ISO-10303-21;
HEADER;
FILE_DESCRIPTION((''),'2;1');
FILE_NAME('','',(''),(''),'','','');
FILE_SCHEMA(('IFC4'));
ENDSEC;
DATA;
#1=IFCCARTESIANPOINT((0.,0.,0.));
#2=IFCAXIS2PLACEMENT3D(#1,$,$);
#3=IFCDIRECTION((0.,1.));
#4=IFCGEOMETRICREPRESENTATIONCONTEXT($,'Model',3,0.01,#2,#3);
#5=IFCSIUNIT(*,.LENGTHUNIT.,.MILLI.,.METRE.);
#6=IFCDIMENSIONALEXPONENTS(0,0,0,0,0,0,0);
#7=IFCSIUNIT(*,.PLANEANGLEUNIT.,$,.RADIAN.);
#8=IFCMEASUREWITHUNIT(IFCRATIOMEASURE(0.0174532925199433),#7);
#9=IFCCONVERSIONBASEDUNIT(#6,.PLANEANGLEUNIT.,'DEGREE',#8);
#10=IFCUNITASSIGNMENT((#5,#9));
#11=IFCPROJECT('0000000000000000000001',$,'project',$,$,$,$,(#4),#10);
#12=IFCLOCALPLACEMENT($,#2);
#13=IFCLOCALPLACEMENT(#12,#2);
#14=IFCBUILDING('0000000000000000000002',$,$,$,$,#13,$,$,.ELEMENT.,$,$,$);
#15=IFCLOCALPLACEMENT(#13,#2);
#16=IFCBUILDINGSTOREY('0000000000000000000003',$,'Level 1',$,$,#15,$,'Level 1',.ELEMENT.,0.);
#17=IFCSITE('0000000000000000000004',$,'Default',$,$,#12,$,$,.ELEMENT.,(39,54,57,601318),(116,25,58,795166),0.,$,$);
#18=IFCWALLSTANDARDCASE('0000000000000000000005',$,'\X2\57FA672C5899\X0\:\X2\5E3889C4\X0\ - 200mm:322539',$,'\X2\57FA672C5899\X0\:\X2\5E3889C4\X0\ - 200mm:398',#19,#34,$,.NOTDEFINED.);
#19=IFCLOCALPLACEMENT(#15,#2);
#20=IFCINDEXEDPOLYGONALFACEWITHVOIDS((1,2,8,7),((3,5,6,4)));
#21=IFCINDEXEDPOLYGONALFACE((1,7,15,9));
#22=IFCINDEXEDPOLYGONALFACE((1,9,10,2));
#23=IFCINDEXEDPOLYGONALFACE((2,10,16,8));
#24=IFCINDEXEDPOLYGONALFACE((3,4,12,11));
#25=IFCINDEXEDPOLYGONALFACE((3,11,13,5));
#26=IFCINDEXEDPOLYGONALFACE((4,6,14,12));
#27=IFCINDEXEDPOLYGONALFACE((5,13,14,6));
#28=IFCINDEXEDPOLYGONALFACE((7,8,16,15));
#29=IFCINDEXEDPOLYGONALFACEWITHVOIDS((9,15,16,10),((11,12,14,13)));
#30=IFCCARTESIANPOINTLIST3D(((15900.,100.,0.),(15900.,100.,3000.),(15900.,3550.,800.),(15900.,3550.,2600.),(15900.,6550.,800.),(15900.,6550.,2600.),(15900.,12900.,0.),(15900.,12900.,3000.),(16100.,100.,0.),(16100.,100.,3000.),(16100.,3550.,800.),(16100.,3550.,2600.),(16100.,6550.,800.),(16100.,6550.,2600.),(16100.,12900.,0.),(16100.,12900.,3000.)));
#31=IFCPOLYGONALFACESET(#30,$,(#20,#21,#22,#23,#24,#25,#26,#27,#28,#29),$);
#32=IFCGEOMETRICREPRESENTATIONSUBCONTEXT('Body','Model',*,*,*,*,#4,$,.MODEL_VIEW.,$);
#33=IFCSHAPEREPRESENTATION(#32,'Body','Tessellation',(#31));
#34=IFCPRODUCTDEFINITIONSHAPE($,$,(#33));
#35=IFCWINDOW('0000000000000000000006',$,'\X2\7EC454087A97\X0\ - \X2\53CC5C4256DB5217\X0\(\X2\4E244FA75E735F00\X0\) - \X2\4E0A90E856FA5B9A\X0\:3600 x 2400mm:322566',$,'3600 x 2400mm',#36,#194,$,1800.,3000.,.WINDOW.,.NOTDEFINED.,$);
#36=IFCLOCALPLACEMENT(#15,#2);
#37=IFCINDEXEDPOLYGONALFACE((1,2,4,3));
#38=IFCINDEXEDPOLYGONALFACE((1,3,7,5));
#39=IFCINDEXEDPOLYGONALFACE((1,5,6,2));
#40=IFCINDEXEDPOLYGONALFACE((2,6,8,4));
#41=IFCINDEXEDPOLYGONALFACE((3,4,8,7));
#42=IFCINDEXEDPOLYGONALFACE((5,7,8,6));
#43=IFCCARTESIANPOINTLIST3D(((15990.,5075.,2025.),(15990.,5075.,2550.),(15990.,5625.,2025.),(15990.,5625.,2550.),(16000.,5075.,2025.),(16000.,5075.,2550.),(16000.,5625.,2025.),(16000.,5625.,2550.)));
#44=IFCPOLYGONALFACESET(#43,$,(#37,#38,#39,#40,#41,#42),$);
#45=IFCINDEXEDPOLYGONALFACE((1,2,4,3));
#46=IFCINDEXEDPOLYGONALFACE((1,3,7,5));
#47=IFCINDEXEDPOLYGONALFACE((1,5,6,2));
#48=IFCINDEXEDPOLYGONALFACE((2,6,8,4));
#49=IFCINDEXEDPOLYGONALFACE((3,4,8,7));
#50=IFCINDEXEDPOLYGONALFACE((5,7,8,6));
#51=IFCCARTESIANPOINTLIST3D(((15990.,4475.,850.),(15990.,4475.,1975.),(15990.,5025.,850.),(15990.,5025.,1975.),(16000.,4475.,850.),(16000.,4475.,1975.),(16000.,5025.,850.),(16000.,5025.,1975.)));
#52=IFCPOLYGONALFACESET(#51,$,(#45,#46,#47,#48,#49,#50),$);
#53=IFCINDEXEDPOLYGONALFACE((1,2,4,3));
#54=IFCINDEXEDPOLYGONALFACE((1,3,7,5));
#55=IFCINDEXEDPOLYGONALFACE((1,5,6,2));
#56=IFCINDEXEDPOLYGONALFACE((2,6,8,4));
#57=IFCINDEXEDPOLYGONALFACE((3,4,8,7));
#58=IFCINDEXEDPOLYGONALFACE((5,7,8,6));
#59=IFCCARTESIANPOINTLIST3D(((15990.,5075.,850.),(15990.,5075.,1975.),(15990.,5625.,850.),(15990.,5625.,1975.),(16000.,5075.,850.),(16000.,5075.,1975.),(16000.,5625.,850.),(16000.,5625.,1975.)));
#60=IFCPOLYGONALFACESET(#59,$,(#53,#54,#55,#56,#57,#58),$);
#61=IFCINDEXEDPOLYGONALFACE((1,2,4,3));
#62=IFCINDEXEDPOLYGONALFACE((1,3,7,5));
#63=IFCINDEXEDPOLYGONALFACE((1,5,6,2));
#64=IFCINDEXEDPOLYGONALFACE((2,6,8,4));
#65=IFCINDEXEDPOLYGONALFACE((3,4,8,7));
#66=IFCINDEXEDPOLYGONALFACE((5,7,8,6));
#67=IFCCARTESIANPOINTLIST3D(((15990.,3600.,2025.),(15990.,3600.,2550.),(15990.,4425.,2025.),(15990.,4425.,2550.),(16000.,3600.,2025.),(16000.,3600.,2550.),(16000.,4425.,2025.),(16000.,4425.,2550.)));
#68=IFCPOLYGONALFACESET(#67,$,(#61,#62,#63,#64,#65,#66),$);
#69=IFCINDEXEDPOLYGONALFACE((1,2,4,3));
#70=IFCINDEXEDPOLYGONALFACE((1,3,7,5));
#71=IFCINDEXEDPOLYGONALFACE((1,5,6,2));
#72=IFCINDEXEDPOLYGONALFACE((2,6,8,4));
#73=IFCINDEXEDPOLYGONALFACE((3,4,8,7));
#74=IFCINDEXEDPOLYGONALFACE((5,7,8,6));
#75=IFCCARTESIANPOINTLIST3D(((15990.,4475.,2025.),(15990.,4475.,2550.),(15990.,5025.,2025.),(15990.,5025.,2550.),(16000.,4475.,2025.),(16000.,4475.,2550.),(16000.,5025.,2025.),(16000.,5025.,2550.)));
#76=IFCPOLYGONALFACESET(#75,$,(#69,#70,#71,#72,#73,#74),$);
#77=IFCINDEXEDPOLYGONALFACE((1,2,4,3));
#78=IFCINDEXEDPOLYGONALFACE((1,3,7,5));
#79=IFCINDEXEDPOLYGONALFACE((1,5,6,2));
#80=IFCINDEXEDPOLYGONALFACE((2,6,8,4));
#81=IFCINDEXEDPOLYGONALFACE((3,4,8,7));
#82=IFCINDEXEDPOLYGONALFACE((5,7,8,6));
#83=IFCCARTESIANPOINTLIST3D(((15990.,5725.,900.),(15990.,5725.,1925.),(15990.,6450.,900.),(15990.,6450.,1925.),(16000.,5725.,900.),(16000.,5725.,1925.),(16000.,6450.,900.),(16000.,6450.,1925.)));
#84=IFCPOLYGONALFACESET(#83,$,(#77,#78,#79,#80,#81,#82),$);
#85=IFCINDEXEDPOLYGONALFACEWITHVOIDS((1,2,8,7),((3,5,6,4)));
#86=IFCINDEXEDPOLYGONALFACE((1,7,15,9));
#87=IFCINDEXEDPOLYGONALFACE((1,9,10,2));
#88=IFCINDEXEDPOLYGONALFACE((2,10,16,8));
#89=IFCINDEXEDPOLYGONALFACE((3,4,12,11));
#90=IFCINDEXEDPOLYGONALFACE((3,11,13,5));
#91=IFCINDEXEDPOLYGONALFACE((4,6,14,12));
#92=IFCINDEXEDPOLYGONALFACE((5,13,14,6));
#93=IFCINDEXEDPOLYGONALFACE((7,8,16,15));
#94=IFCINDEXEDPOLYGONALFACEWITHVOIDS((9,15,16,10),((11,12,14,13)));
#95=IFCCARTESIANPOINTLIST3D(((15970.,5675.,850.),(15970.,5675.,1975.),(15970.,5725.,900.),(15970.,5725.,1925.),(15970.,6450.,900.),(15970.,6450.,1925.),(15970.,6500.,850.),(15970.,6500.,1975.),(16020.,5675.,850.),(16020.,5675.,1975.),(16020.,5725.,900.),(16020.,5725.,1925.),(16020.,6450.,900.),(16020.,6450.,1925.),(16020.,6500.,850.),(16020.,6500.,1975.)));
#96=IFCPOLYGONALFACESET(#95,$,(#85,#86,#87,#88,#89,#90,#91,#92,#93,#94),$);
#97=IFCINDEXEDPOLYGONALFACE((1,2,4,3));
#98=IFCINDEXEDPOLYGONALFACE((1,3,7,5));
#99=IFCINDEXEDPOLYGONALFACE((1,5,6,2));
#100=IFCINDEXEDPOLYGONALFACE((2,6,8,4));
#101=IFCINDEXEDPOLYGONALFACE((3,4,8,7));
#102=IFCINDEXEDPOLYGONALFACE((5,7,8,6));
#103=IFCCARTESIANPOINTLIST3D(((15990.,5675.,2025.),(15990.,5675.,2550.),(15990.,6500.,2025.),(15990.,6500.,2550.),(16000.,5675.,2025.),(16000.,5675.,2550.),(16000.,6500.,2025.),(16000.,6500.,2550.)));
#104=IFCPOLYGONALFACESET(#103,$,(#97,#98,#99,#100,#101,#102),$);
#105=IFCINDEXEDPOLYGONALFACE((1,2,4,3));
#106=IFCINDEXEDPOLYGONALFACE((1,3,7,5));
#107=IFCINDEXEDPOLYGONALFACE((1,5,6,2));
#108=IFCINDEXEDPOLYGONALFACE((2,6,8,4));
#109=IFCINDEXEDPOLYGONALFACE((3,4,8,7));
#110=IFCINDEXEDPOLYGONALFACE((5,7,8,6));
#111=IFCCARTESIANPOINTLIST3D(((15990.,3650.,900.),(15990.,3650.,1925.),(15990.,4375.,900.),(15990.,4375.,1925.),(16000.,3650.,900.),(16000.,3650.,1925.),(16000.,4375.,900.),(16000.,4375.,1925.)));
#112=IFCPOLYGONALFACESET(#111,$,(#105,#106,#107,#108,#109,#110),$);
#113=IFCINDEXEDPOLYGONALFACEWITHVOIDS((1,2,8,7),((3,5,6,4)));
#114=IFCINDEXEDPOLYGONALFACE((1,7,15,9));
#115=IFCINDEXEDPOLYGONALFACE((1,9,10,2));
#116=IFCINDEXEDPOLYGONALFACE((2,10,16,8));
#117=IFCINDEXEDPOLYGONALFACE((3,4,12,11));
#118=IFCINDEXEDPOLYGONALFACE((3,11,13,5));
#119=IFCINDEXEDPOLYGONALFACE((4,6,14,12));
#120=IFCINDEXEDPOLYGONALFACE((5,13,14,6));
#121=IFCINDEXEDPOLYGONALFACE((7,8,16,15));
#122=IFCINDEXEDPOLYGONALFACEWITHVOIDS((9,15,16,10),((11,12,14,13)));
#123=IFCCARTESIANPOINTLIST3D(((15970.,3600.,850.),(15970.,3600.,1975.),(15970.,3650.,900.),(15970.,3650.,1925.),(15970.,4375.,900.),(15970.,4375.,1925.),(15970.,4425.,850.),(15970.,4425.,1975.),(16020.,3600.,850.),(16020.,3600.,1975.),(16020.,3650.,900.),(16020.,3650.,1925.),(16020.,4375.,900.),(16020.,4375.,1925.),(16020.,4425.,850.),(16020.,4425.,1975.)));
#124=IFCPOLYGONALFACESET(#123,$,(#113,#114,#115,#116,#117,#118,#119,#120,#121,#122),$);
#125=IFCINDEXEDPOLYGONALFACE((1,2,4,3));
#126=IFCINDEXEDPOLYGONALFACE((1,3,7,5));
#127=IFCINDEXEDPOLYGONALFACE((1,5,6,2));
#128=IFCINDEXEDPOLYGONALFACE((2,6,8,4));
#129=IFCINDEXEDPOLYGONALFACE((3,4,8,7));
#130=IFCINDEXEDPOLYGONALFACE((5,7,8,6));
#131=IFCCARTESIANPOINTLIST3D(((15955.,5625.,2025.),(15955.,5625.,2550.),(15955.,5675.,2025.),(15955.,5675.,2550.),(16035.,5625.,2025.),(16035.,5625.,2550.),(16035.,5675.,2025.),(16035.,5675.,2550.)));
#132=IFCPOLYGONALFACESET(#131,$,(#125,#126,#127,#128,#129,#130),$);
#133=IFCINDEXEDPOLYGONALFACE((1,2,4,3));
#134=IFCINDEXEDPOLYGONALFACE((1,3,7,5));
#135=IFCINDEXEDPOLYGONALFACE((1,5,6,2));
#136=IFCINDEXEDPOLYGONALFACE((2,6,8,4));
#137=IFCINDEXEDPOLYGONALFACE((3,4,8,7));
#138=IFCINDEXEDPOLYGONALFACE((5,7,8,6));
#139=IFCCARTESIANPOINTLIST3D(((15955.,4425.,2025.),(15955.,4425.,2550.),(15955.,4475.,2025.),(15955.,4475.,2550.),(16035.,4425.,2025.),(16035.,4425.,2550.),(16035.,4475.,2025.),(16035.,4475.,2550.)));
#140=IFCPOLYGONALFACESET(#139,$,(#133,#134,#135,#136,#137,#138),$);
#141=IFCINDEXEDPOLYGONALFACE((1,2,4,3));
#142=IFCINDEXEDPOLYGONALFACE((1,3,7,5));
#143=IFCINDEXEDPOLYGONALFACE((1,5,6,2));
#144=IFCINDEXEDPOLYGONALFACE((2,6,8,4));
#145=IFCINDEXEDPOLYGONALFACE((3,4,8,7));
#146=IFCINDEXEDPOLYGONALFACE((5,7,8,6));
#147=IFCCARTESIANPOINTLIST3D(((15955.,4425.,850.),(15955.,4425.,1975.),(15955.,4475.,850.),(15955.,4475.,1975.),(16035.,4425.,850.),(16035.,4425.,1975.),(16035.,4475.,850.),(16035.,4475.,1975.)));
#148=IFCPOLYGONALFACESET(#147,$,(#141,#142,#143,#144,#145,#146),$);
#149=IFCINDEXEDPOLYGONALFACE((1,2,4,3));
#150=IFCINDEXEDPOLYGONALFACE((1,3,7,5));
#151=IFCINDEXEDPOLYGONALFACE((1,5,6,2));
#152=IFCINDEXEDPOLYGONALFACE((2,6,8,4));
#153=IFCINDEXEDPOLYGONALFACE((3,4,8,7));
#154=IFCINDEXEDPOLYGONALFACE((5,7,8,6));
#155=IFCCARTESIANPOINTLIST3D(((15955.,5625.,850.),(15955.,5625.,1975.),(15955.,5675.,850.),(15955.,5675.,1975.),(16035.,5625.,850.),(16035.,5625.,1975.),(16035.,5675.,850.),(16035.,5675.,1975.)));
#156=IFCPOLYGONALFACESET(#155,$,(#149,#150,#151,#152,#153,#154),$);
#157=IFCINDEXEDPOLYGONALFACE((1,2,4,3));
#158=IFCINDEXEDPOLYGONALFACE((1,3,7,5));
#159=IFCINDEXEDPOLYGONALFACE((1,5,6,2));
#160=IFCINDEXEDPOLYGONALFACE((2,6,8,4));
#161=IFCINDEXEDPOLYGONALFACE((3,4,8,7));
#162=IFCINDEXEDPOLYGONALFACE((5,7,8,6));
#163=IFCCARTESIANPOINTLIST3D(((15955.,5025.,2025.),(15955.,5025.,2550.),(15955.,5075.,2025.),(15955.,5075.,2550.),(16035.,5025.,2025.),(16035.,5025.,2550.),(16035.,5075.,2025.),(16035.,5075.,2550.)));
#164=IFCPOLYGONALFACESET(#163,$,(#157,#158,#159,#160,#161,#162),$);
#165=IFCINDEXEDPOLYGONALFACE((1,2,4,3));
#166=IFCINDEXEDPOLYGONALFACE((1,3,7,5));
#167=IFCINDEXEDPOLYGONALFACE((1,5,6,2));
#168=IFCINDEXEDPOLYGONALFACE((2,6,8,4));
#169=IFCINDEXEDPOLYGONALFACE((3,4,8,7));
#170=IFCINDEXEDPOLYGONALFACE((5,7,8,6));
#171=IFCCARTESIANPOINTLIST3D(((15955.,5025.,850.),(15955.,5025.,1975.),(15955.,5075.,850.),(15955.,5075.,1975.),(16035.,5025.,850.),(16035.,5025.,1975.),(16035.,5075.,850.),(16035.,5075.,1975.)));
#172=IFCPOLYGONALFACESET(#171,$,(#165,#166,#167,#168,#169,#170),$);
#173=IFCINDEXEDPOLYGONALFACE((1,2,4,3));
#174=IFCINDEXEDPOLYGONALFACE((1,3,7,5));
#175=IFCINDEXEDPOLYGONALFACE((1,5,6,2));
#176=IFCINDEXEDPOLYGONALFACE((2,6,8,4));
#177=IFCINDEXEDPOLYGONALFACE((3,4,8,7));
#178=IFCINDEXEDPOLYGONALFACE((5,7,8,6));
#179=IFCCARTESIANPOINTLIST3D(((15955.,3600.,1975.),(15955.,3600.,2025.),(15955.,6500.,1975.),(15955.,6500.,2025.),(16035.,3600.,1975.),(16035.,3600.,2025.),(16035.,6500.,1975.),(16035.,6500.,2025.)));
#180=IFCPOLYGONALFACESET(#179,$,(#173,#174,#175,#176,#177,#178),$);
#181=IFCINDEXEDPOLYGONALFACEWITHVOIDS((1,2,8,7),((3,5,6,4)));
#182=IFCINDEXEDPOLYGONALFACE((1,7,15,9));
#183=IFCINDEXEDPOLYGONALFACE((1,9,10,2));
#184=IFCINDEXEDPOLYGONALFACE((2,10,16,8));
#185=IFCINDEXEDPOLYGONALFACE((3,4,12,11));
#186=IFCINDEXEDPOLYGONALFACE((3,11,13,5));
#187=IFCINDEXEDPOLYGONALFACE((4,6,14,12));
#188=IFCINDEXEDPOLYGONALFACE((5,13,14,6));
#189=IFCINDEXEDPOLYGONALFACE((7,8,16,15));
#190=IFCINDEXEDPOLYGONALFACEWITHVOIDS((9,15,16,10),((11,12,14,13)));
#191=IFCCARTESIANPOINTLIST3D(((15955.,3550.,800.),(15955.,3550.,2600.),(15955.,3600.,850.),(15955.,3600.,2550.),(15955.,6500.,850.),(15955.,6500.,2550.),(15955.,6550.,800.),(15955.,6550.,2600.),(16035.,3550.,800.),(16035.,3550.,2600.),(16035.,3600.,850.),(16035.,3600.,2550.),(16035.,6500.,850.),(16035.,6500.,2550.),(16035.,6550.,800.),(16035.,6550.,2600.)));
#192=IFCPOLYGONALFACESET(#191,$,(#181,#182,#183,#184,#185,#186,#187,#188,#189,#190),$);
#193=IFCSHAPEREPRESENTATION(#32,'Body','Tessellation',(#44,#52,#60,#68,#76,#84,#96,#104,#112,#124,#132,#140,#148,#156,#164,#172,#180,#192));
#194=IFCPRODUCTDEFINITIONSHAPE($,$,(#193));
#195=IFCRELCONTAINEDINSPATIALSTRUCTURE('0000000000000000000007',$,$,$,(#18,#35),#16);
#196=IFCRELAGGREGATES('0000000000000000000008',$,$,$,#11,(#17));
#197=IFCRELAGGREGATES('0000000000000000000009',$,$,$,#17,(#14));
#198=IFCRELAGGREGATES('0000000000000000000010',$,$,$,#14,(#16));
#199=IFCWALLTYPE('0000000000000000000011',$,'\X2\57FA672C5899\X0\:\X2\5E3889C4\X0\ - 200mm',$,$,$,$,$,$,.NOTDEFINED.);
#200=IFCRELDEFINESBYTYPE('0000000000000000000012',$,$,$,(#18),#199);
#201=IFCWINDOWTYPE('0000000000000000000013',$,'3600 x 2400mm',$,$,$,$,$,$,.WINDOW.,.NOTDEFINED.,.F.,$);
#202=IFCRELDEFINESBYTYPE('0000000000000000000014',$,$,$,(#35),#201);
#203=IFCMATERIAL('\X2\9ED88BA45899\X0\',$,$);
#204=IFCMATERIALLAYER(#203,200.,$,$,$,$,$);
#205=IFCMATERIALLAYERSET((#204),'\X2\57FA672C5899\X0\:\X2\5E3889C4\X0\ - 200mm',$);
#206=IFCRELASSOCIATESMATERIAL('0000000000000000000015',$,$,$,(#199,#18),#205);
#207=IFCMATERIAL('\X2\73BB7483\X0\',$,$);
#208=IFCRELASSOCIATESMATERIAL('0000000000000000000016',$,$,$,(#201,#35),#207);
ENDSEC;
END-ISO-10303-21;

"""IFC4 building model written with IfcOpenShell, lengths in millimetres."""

from ifc_helpers import new_model, entity, si_unit, converted_unit, direction, frame, frame_2d, origin, origin_2d_with_axis, place, context, subcontext, project, spatial, polyline, rectangle, outline, extrude, source, transform, mapped, material, layer, layer_set, layer_usage, type_object, type_shapes, element, fill, save


model = new_model("IFC4")

# Units and contexts
model_context_1 = context("Model", 3, precision=0.01, world=origin(), true_north=direction((0.0, 1.0)))
body_context_1 = subcontext(model_context_1, "Body", "Model", "MODEL_VIEW")
ifc_project = project(units=[si_unit("LENGTHUNIT", "METRE", prefix="MILLI"), converted_unit("PLANEANGLEUNIT", "DEGREE", entity("IfcRatioMeasure", 0.0174532925199433), si_unit("PLANEANGLEUNIT", "RADIAN"), dimensions=[0, 0, 0, 0, 0, 0, 0])], contexts=[model_context_1])

# Site, building, storey
site_placement = place(None, origin())
site = spatial("IfcSite", under=ifc_project, at=site_placement, Name="Default", CompositionType="ELEMENT", RefLatitude=(39, 54, 57, 601318), RefLongitude=(116, 25, 58, 795166), RefElevation=0.0)
building_placement = place(site_placement, origin())
building = spatial("IfcBuilding", under=site, at=building_placement, CompositionType="ELEMENT")
storey_placement = place(building_placement, origin())
storey = spatial("IfcBuildingStorey", under=building, at=storey_placement, Name="Level 1", LongName="Level 1", CompositionType="ELEMENT", Elevation=0.0)

# Shared definitions
ifc_material_1 = material(Name="默认墙")
ifc_layer = layer(ifc_material_1, 200.0)
ifc_layer_set = layer_set([ifc_layer], Name="基本墙:常规 - 200mm")
wall_type = type_object("IfcWallType", Name="基本墙:常规 - 200mm", PredefinedType="NOTDEFINED", material=ifc_layer_set)
ifc_material_2 = material(Name="玻璃")
window_type = type_object("IfcWindowType", Name="3600 x 2400mm", ParameterTakesPrecedence=False, PartitioningType="NOTDEFINED", PredefinedType="WINDOW", material=ifc_material_2)
shared_shape_1 = source(origin(), body_context_1, "Body", "SweptSolid", [
    extrude(rectangle(XDim=10.0, YDim=550.0, at=origin_2d_with_axis()), frame((1200.0, 95.0, 1225.0), z_axis=(0.0, 0.0, 1.0), x_axis=(0.0, 1.0, 0.0)), (0.0, 0.0, 1.0), 525.0),
    extrude(rectangle(XDim=10.0, YDim=550.0, at=origin_2d_with_axis()), frame((1800.0, 95.0, 50.0), z_axis=(0.0, 0.0, 1.0), x_axis=(0.0, 1.0, 0.0)), (0.0, 0.0, 1.0), 1125.0),
    extrude(rectangle(XDim=10.0, YDim=550.0, at=origin_2d_with_axis()), frame((1200.0, 95.0, 50.0), z_axis=(0.0, 0.0, 1.0), x_axis=(0.0, 1.0, 0.0)), (0.0, 0.0, 1.0), 1125.0),
    extrude(rectangle(XDim=10.0, YDim=825.0, at=frame_2d((0.0, 0.0), x_axis=(1.0, 0.0))), frame((2537.5, 95.0, 1225.0), z_axis=(0.0, 0.0, 1.0), x_axis=(0.0, 1.0, 0.0)), (0.0, 0.0, 1.0), 525.0),
    extrude(rectangle(XDim=10.0, YDim=550.0, at=frame_2d((0.0, 0.0), x_axis=(1.0, 0.0))), frame((1800.0, 95.0, 1225.0), z_axis=(0.0, 0.0, 1.0), x_axis=(0.0, 1.0, 0.0)), (0.0, 0.0, 1.0), 525.0),
    extrude(rectangle(XDim=10.0, YDim=725.0, at=frame_2d((0.0, 0.0), x_axis=(1.0, 0.0))), frame((462.5, 95.0, 100.0), z_axis=(0.0, 0.0, 1.0), x_axis=(0.0, 1.0, 0.0)), (0.0, 0.0, 1.0), 1025.0),
    extrude(outline(polyline([(-562.5, -412.5), (562.5, -412.5), (562.5, 412.5), (-562.5, 412.5), (-562.5, -412.5)]), holes=[polyline([(512.5, -362.5), (-512.5, -362.5), (-512.5, 362.5), (512.5, 362.5), (512.5, -362.5)])]), frame((462.5, 70.0, 612.5), z_axis=(0.0, 1.0, 0.0), x_axis=(0.0, 0.0, -1.0)), (0.0, 0.0, 1.0), 50.0),
    extrude(rectangle(XDim=10.0, YDim=825.0, at=origin_2d_with_axis()), frame((462.5, 95.0, 1225.0), z_axis=(0.0, 0.0, 1.0), x_axis=(0.0, 1.0, 0.0)), (0.0, 0.0, 1.0), 525.0),
    extrude(rectangle(XDim=10.0, YDim=725.0, at=frame_2d((0.0, 0.0), x_axis=(1.0, 0.0))), frame((2537.5, 95.0, 100.0), z_axis=(0.0, 0.0, 1.0), x_axis=(0.0, 1.0, 0.0)), (0.0, 0.0, 1.0), 1025.0),
    extrude(outline(polyline([(-562.5, -412.5), (562.5, -412.5), (562.5, 412.5), (-562.5, 412.5), (-562.5, -412.5)]), holes=[polyline([(512.5, -362.5), (-512.5, -362.5), (-512.5, 362.5), (512.5, 362.5), (512.5, -362.5)])]), frame((2537.5, 70.0, 612.5), z_axis=(0.0, 1.0, 0.0), x_axis=(0.0, 0.0, -1.0)), (0.0, 0.0, 1.0), 50.0),
    extrude(rectangle(XDim=80.0, YDim=50.0, at=origin_2d_with_axis()), frame((900.0, 95.0, 1225.0), z_axis=(0.0, 0.0, 1.0), x_axis=(0.0, -1.0, 0.0)), (0.0, 0.0, 1.0), 525.0),
    extrude(rectangle(XDim=80.0, YDim=50.0, at=frame_2d((0.0, 0.0), x_axis=(1.0, 0.0))), frame((2100.0, 95.0, 1225.0), z_axis=(0.0, 0.0, 1.0), x_axis=(0.0, -1.0, 0.0)), (0.0, 0.0, 1.0), 525.0),
    extrude(rectangle(XDim=80.0, YDim=50.0, at=origin_2d_with_axis()), frame((2100.0, 95.0, 50.0), z_axis=(0.0, 0.0, 1.0), x_axis=(0.0, -1.0, 0.0)), (0.0, 0.0, 1.0), 1125.0),
    extrude(rectangle(XDim=80.0, YDim=50.0, at=origin_2d_with_axis()), frame((900.0, 95.0, 50.0), z_axis=(0.0, 0.0, 1.0), x_axis=(0.0, -1.0, 0.0)), (0.0, 0.0, 1.0), 1125.0),
    extrude(rectangle(XDim=80.0, YDim=50.0, at=frame_2d((0.0, 0.0), x_axis=(1.0, 0.0))), frame((1500.0, 95.0, 1225.0), z_axis=(0.0, 0.0, 1.0), x_axis=(0.0, -1.0, 0.0)), (0.0, 0.0, 1.0), 525.0),
    extrude(rectangle(XDim=80.0, YDim=50.0, at=origin_2d_with_axis()), frame((1500.0, 95.0, 50.0), z_axis=(0.0, 0.0, 1.0), x_axis=(0.0, -1.0, 0.0)), (0.0, 0.0, 1.0), 1125.0),
    extrude(rectangle(XDim=80.0, YDim=2900.0, at=frame_2d((0.0, 0.0), x_axis=(1.0, 0.0))), frame((1500.0, 95.0, 1175.0), z_axis=(0.0, 0.0, 1.0), x_axis=(0.0, -1.0, 0.0)), (0.0, 0.0, 1.0), 50.0),
    extrude(outline(polyline([(-1500.0, -900.0), (1500.0, -900.0), (1500.0, 900.0), (-1500.0, 900.0), (-1500.0, -900.0)]), holes=[polyline([(1450.0, -850.0), (-1450.0, -850.0), (-1450.0, 850.0), (1450.0, 850.0), (1450.0, -850.0)])]), frame((1500.0, 55.0, 900.0), z_axis=(0.0, 1.0, 0.0), x_axis=(1.0, 0.0, 0.0)), (0.0, 0.0, 1.0), 80.0),
])
type_shapes(window_type, [shared_shape_1])

# Wall, opening, window
ifc_layer_usage_1 = layer_usage(ifc_layer_set, "AXIS2", "NEGATIVE", 100.0)
wall_1_placement = place(storey_placement, frame((16000.0, 12900.0, 0.0), z_axis=(0.0, 0.0, 1.0), x_axis=(0.0, -1.0, 0.0)))
wall_1 = element("IfcWallStandardCase", 1, at=wall_1_placement, inside=storey, type_object=wall_type, material=ifc_layer_usage_1, Name="基本墙:常规 - 200mm:322539", ObjectType="基本墙:常规 - 200mm:398", PredefinedType="NOTDEFINED", context=body_context_1, shape_type="SweptSolid", body=[
    extrude(rectangle(XDim=12800.0, YDim=200.0, at=frame_2d((6400.0, 0.0), x_axis=(-1.0, 0.0))), origin(), (0.0, 0.0, 1.0), 3000.0),
])
opening_1_placement = place(wall_1_placement, frame((6350.0, -100.0, 800.0)))
opening_1 = element("IfcOpeningElement", 2, at=opening_1_placement, cuts=wall_1, ObjectType="Opening", PredefinedType="OPENING", context=body_context_1, shape_type="SweptSolid", body=[
    extrude(rectangle(XDim=1800.0, YDim=3000.0, at=frame_2d((900.0, 1500.0), x_axis=(1.0, 0.0))), frame((0.0, 0.0, 0.0), z_axis=(0.0, 1.0, 0.0), x_axis=(0.0, 0.0, 1.0)), (0.0, 0.0, 1.0), 200.0),
])
window_1_placement = place(opening_1_placement, origin())
window_1 = element("IfcWindow", 3, at=window_1_placement, inside=storey, type_object=window_type, material=ifc_material_2, Name="组合窗 - 双层四列(两侧平开) - 上部固定:3600 x 2400mm:322566", ObjectType="3600 x 2400mm", OverallHeight=1800.0, OverallWidth=3000.0, PartitioningType="NOTDEFINED", PredefinedType="WINDOW", context=body_context_1, shape_type="MappedRepresentation", body=[
    mapped(shared_shape_1, transform((0.0, 0.0, 0.0), scale=1.0)),
])
fill(opening_1, window_1)

save(model, "model.ifc")
